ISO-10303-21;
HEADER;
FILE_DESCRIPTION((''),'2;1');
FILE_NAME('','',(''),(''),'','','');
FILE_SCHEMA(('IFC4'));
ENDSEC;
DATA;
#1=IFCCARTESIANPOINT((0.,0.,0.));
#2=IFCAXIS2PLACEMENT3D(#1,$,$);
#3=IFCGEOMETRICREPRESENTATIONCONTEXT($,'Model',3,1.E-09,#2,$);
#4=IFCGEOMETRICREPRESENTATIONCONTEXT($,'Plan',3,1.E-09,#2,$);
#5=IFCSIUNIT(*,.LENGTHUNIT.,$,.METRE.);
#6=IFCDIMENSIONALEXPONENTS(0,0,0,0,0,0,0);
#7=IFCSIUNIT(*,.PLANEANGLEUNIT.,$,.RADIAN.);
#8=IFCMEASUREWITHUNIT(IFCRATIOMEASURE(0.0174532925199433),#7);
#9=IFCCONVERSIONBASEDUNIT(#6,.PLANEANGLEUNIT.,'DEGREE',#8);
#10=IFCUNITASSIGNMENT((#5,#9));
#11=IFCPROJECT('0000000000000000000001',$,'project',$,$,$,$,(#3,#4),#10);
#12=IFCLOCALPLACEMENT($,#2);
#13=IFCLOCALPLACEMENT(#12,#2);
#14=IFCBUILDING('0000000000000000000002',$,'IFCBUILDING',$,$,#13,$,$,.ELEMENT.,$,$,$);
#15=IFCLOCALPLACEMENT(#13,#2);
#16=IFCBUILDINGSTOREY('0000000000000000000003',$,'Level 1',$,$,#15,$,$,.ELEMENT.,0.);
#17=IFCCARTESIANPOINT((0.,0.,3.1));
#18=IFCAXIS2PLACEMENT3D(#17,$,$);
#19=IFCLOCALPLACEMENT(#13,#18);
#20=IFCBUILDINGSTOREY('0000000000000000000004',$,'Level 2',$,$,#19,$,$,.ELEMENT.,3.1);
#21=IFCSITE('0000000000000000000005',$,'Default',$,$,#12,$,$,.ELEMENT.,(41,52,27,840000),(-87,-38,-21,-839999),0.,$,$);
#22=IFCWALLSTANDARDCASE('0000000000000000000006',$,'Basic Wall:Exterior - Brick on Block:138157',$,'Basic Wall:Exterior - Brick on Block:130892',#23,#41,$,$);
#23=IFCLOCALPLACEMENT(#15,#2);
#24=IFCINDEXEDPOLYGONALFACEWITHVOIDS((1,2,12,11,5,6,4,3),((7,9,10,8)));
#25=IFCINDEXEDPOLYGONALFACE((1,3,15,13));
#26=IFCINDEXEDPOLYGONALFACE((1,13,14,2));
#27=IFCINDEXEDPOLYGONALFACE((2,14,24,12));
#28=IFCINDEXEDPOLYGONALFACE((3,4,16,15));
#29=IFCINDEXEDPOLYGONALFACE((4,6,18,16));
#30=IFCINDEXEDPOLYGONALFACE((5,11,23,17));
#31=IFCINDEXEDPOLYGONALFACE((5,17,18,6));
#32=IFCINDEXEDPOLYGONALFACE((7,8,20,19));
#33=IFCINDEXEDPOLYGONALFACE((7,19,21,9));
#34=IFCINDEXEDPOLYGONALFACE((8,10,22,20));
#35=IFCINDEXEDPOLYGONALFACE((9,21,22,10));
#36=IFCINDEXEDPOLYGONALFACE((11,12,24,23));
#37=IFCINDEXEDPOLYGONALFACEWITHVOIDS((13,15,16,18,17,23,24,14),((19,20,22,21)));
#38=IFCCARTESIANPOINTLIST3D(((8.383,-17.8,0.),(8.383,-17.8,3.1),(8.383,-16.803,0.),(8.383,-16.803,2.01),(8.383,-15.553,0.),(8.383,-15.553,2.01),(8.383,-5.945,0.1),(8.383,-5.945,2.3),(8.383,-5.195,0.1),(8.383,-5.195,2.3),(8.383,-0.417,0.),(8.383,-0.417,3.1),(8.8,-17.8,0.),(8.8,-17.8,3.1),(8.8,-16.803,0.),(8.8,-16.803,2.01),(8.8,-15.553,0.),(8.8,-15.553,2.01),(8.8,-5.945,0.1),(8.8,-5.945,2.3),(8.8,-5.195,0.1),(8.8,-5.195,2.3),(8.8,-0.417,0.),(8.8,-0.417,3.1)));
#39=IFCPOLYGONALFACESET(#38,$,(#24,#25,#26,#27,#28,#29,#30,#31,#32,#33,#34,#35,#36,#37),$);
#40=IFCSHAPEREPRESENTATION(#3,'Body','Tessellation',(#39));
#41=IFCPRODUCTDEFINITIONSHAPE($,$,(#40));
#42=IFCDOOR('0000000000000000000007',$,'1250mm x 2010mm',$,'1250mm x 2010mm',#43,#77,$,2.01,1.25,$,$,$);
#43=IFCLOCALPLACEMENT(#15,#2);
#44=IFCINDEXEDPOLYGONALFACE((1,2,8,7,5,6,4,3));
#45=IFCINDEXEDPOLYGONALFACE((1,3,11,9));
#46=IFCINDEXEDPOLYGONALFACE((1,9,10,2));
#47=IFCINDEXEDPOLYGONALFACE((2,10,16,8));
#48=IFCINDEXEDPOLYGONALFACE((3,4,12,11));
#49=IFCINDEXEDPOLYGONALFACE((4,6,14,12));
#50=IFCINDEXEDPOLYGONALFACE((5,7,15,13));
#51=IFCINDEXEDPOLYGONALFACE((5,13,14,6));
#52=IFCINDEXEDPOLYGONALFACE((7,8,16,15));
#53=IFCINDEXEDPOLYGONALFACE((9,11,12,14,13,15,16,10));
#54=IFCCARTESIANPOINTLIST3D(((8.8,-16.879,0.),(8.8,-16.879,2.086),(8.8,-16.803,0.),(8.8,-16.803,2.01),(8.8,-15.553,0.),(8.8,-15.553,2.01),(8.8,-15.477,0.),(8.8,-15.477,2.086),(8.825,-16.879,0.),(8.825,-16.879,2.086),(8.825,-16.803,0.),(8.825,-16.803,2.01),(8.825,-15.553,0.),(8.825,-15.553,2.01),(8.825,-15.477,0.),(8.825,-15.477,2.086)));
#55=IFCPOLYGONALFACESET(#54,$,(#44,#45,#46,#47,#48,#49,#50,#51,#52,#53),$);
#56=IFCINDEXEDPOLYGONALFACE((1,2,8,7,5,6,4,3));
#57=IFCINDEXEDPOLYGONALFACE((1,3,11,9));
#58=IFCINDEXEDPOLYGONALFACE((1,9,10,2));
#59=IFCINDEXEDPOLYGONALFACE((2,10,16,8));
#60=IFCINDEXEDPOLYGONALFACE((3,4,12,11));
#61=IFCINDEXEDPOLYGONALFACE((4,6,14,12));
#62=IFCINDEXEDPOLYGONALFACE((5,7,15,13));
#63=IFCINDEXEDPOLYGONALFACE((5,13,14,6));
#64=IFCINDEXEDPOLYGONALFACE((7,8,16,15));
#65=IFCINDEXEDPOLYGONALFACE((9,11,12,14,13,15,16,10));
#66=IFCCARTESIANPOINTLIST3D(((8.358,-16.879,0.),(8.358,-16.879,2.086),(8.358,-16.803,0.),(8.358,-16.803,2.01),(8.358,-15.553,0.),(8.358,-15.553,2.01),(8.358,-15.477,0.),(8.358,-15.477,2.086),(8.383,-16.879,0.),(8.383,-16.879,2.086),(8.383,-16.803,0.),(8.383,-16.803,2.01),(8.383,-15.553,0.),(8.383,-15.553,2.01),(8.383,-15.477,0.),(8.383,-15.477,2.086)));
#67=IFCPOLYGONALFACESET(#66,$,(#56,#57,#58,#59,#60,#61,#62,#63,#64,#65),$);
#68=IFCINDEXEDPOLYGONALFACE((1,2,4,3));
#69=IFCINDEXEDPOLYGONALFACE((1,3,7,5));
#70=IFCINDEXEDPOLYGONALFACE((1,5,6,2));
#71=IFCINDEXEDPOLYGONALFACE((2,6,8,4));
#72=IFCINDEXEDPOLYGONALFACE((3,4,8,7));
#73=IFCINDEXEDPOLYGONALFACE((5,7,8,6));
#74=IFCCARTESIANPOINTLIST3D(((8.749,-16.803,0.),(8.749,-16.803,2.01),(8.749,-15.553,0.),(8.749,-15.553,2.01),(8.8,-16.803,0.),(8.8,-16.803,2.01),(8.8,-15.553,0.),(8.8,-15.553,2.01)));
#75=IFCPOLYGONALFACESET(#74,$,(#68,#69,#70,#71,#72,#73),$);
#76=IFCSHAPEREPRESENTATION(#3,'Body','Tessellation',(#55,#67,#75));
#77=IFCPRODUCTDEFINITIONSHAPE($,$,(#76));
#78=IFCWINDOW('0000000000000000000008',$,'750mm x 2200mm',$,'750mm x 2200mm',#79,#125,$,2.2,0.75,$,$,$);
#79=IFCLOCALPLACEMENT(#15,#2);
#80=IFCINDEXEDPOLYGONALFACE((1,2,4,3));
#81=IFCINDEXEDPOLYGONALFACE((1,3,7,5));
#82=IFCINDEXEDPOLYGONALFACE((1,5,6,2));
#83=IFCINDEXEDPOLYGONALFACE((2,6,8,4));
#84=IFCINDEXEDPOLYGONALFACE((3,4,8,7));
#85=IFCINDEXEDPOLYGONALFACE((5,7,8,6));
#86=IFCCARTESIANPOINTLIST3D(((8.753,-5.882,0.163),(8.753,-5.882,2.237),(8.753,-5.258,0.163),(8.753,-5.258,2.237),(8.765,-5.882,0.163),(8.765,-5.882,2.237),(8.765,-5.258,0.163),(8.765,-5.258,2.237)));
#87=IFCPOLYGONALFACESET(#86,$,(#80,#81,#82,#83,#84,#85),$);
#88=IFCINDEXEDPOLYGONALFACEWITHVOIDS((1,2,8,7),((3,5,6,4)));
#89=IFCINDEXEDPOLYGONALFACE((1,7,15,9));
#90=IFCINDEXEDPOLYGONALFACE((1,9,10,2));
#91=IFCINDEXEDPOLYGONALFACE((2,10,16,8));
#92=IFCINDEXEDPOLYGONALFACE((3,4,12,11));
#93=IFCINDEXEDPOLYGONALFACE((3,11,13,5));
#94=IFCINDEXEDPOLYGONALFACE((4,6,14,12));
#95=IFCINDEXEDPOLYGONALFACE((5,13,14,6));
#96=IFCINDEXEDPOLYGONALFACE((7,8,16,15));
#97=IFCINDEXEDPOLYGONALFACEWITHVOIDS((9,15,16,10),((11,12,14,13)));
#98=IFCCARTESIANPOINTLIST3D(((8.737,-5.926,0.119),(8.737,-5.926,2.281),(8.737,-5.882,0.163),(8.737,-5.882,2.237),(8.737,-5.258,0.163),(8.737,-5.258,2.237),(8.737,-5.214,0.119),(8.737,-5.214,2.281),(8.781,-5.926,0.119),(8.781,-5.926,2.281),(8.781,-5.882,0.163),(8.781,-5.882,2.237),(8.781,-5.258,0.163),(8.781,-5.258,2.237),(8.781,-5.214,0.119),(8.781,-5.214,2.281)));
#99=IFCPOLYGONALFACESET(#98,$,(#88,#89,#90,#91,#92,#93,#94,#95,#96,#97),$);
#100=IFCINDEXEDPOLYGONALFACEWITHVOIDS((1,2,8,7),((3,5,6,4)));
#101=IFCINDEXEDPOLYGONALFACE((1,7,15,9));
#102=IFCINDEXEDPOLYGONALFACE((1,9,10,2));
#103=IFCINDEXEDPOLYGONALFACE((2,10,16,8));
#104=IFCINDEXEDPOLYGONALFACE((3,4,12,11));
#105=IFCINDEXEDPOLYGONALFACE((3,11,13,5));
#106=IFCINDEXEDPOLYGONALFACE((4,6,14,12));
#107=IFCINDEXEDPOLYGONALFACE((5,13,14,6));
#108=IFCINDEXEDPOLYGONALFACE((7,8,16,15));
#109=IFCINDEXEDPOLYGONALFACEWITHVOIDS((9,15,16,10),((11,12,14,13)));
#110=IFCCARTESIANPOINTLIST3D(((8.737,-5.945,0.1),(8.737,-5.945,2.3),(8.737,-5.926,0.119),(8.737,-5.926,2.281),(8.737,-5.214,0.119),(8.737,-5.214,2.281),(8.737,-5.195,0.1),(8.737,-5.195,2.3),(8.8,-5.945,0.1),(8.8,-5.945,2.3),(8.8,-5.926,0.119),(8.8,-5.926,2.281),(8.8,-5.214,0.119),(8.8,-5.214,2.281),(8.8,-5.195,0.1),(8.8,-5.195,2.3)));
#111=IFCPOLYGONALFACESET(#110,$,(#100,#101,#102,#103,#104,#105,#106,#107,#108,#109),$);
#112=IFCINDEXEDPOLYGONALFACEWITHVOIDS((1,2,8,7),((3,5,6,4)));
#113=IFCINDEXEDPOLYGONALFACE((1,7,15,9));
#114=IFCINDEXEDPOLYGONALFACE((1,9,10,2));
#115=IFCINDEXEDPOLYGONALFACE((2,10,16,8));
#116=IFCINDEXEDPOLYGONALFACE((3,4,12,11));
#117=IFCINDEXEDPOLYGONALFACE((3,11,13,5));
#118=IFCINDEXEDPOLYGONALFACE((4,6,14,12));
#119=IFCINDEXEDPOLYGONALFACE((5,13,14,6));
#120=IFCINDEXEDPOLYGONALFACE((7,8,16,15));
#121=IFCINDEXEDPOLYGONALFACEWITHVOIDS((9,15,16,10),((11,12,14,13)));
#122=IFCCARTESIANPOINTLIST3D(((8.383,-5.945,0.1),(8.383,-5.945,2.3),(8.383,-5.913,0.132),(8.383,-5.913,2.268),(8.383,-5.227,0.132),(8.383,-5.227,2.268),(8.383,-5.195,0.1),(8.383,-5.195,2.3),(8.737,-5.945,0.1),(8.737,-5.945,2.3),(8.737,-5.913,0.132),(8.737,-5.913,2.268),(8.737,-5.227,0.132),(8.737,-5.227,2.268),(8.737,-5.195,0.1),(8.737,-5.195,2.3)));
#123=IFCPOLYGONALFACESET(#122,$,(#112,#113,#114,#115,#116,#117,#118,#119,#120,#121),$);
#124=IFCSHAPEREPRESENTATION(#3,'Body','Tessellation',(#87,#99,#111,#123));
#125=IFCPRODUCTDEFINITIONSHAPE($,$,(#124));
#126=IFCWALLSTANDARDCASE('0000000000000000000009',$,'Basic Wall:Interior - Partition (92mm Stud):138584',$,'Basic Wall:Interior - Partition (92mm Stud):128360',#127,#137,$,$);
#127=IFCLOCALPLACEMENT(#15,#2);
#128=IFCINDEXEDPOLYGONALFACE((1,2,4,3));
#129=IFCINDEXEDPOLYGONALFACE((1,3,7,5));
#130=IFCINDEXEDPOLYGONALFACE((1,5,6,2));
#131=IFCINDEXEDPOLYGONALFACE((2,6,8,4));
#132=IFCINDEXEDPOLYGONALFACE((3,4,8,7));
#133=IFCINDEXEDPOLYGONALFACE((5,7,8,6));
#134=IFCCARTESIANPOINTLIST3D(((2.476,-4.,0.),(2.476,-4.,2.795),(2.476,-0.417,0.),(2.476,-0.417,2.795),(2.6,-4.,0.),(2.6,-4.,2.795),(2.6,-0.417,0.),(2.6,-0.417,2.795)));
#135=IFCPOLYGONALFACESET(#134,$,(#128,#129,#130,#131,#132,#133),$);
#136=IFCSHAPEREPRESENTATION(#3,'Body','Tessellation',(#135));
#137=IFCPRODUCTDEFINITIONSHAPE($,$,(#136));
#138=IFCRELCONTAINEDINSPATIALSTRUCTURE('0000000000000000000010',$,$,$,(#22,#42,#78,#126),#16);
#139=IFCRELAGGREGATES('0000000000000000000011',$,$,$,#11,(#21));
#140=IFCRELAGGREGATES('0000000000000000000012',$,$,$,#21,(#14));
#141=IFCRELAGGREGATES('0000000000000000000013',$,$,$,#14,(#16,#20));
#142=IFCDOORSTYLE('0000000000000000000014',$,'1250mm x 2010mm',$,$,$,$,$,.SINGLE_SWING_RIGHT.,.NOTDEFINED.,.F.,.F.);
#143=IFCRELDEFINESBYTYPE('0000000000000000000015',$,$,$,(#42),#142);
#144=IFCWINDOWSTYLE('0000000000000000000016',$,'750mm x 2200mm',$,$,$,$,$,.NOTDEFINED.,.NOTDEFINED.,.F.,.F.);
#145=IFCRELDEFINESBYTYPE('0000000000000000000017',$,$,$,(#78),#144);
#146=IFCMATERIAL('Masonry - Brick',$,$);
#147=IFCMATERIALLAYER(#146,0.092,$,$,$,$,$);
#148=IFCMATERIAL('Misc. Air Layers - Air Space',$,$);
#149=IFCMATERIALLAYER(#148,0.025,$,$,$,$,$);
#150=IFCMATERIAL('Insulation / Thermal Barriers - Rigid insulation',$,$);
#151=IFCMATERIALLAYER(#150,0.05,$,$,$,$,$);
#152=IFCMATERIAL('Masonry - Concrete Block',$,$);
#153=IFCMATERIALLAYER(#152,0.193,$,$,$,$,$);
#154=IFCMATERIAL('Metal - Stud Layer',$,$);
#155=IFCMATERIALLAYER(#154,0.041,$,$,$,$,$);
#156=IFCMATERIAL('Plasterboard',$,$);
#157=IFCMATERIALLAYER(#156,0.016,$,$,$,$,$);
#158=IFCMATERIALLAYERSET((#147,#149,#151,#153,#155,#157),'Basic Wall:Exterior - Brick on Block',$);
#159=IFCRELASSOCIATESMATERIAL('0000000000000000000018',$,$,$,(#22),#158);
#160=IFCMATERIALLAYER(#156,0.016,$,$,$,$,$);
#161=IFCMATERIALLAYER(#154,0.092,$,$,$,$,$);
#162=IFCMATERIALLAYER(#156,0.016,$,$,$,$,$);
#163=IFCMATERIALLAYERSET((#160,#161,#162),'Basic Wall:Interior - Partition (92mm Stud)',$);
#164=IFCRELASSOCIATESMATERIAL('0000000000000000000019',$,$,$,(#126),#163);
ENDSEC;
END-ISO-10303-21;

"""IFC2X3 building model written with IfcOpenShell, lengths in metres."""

from ifc_helpers import new_model, entity, si_unit, converted_unit, frame, frame_2d, origin, origin_2d_with_axis, place, context, project, spatial, polyline, rectangle, outline, extrude, source, transform, mapped, material, layer, layer_set, layer_usage, type_object, type_shapes, element, fill, save


model = new_model("IFC2X3")

# Units and contexts
model_context = context("Model", 3, precision=1e-09, world=origin())
plan_context = context("Plan", 3, precision=1e-09, world=origin())
ifc_project = project(units=[si_unit("LENGTHUNIT", "METRE"), converted_unit("PLANEANGLEUNIT", "DEGREE", entity("IfcRatioMeasure", 0.0174532925199433), si_unit("PLANEANGLEUNIT", "RADIAN"), dimensions=[0, 0, 0, 0, 0, 0, 0])], contexts=[model_context, plan_context])

# Site, building, storey
site_placement = place(None, origin())
site = spatial("IfcSite", under=ifc_project, at=site_placement, Name="Default", CompositionType="ELEMENT", RefLatitude=(41, 52, 27, 840000), RefLongitude=(-87, -38, -21, -839999), RefElevation=0.0)
building_placement = place(site_placement, origin())
building = spatial("IfcBuilding", under=site, at=building_placement, Name="IFCBUILDING", CompositionType="ELEMENT")
storey_1_placement = place(building_placement, origin())
storey_1 = spatial("IfcBuildingStorey", under=building, at=storey_1_placement, Name="Level 1", CompositionType="ELEMENT", Elevation=0.0)

# Shared definitions
ifc_material_1 = material(Name="Masonry - Brick")
ifc_layer_1 = layer(ifc_material_1, 0.092)
ifc_material_2 = material(Name="Misc. Air Layers - Air Space")
ifc_layer_2 = layer(ifc_material_2, 0.025)
ifc_material_3 = material(Name="Insulation / Thermal Barriers - Rigid insulation")
ifc_layer_3 = layer(ifc_material_3, 0.05)
ifc_material_4 = material(Name="Masonry - Concrete Block")
ifc_layer_4 = layer(ifc_material_4, 0.193)
ifc_material_5 = material(Name="Metal - Stud Layer")
ifc_layer_5 = layer(ifc_material_5, 0.041)
ifc_material_6 = material(Name="Plasterboard")
ifc_layer_6 = layer(ifc_material_6, 0.016)
ifc_layer_set_1 = layer_set([ifc_layer_1, ifc_layer_2, ifc_layer_3, ifc_layer_4, ifc_layer_5, ifc_layer_6], Name="Basic Wall:Exterior - Brick on Block")

# Wall, openings, door, window
ifc_layer_usage_1 = layer_usage(ifc_layer_set_1, "AXIS2", "NEGATIVE", 0.2085)
wall_1_placement = place(storey_1_placement, frame((8.5915, -0.417, 0.0), z_axis=(0.0, 0.0, 1.0), x_axis=(0.0, -1.0, 0.0)))
wall_1 = element("IfcWallStandardCase", 1, at=wall_1_placement, inside=storey_1, material=ifc_layer_usage_1, Name="Basic Wall:Exterior - Brick on Block:138157", ObjectType="Basic Wall:Exterior - Brick on Block:130892", context=model_context, shape_type="SweptSolid", body=[
    extrude(rectangle(XDim=17.383, YDim=0.417, at=frame_2d((8.6915, 0.0), x_axis=(-1.0, 0.0))), origin(), (0.0, 0.0, 1.0), 3.1),
])
opening_1_placement = place(wall_1_placement, frame((15.136, -0.2085, 0.0)))
opening_1 = element("IfcOpeningElement", 2, at=opening_1_placement, cuts=wall_1, ObjectType="Opening", context=model_context, shape_type="SweptSolid", body=[
    extrude(rectangle(XDim=1.25, YDim=2.01, at=frame_2d((1.005, 0.625), x_axis=(0.0, 1.0))), frame((0.0, 0.0, 0.0), z_axis=(0.0, 1.0, 0.0), x_axis=(0.0, 0.0, 1.0)), (0.0, 0.0, 1.0), 0.417),
])
opening_2_placement = place(wall_1_placement, frame((4.778, -0.2085, 0.1)))
opening_2 = element("IfcOpeningElement", 3, at=opening_2_placement, cuts=wall_1, ObjectType="Opening", context=model_context, shape_type="SweptSolid", body=[
    extrude(rectangle(XDim=2.2, YDim=0.75, at=frame_2d((1.1, 0.375), x_axis=(1.0, 0.0))), frame((0.0, 0.0, 0.0), z_axis=(0.0, 1.0, 0.0), x_axis=(0.0, 0.0, 1.0)), (0.0, 0.0, 1.0), 0.417),
])
door_style_1 = type_object("IfcDoorStyle", Name="1250mm x 2010mm", ConstructionType="NOTDEFINED", OperationType="SINGLE_SWING_RIGHT", ParameterTakesPrecedence=False, Sizeable=False)
shared_shape_1 = source(origin(), model_context, "Body", "SweptSolid", [
    extrude(outline(polyline([(-0.701, -1.062), (0.701, -1.062), (0.701, 1.024), (0.625, 1.024), (0.625, -0.986), (-0.625, -0.986), (-0.625, 1.024), (-0.701, 1.024), (-0.701, -1.062)])), frame((0.625, 0.417, 1.024), z_axis=(0.0, 1.0, 0.0), x_axis=(1.0, 0.0, 0.0)), (0.0, 0.0, 1.0), 0.025),
    extrude(outline(polyline([(-1.062, -0.701), (1.024, -0.701), (1.024, -0.625), (-0.986, -0.625), (-0.986, 0.625), (1.024, 0.625), (1.024, 0.701), (-1.062, 0.701), (-1.062, -0.701)])), frame((0.625, -0.025, 1.024), z_axis=(0.0, 1.0, 0.0), x_axis=(0.0, 0.0, -1.0)), (0.0, 0.0, 1.0), 0.025),
    extrude(rectangle(XDim=0.051, YDim=1.25, at=origin_2d_with_axis()), frame((0.625, 0.3915, 0.0), z_axis=(0.0, 0.0, 1.0), x_axis=(0.0, 1.0, 0.0)), (0.0, 0.0, 1.0), 2.01),
])
type_shapes(door_style_1, [shared_shape_1])
door_1_placement = place(opening_1_placement, origin())
door_1 = element("IfcDoor", 4, at=door_1_placement, inside=storey_1, type_object=door_style_1, Name="1250mm x 2010mm", ObjectType="1250mm x 2010mm", OverallHeight=2.01, OverallWidth=1.25, context=model_context, shape_type="MappedRepresentation", body=[
    mapped(shared_shape_1, transform((0.0, 0.0, 0.0), scale=1.0)),
])
fill(opening_1, door_1)
window_style_1 = type_object("IfcWindowStyle", Name="750mm x 2200mm", ConstructionType="NOTDEFINED", OperationType="NOTDEFINED", ParameterTakesPrecedence=False, Sizeable=False)
shared_shape_2 = source(origin(), model_context, "Body", "SweptSolid", [
    extrude(rectangle(XDim=0.012, YDim=0.624, at=origin_2d_with_axis()), frame((0.375, 0.376, 0.063), z_axis=(0.0, 0.0, 1.0), x_axis=(0.0, -1.0, 0.0)), (0.0, 0.0, 1.0), 2.074),
    extrude(outline(polyline([(-0.356, -1.081), (0.356, -1.081), (0.356, 1.081), (-0.356, 1.081), (-0.356, -1.081)]), holes=[polyline([(-0.312, -1.037), (-0.312, 1.037), (0.312, 1.037), (0.312, -1.037), (-0.312, -1.037)])]), frame((0.375, 0.354, 1.1), z_axis=(0.0, 1.0, 0.0), x_axis=(1.0, 0.0, 0.0)), (0.0, 0.0, 1.0), 0.044),
    extrude(outline(polyline([(-0.375, -1.1), (0.375, -1.1), (0.375, 1.1), (-0.375, 1.1), (-0.375, -1.1)]), holes=[polyline([(-0.356, -1.081), (-0.356, 1.081), (0.356, 1.081), (0.356, -1.081), (-0.356, -1.081)])]), frame((0.375, 0.354, 1.1), z_axis=(0.0, 1.0, 0.0), x_axis=(1.0, 0.0, 0.0)), (0.0, 0.0, 1.0), 0.063),
    extrude(outline(polyline([(-0.375, -1.1), (0.375, -1.1), (0.375, 1.1), (-0.375, 1.1), (-0.375, -1.1)]), holes=[polyline([(-0.343, -1.068), (-0.343, 1.068), (0.343, 1.068), (0.343, -1.068), (-0.343, -1.068)])]), frame((0.375, 0.0, 1.1), z_axis=(0.0, 1.0, 0.0), x_axis=(1.0, 0.0, 0.0)), (0.0, 0.0, 1.0), 0.354),
])
type_shapes(window_style_1, [shared_shape_2])
window_1_placement = place(opening_2_placement, origin())
window_1 = element("IfcWindow", 5, at=window_1_placement, inside=storey_1, type_object=window_style_1, Name="750mm x 2200mm", ObjectType="750mm x 2200mm", OverallHeight=2.2, OverallWidth=0.75, context=model_context, shape_type="MappedRepresentation", body=[
    mapped(shared_shape_2, transform((0.0, 0.0, 0.0), scale=1.0)),
])
fill(opening_2, window_1)

# Wall
ifc_layer_7 = layer(ifc_material_6, 0.016)
ifc_layer_8 = layer(ifc_material_5, 0.092)
ifc_layer_9 = layer(ifc_material_6, 0.016)
ifc_layer_set_2 = layer_set([ifc_layer_7, ifc_layer_8, ifc_layer_9], Name="Basic Wall:Interior - Partition (92mm Stud)")
ifc_layer_usage_2 = layer_usage(ifc_layer_set_2, "AXIS2", "NEGATIVE", 0.062)
wall_2_placement = place(storey_1_placement, frame((2.538, -0.417, 0.0), z_axis=(0.0, 0.0, 1.0), x_axis=(0.0, -1.0, 0.0)))
element("IfcWallStandardCase", 6, at=wall_2_placement, inside=storey_1, material=ifc_layer_usage_2, Name="Basic Wall:Interior - Partition (92mm Stud):138584", ObjectType="Basic Wall:Interior - Partition (92mm Stud):128360", context=model_context, shape_type="SweptSolid", body=[
    extrude(rectangle(XDim=3.583, YDim=0.124, at=frame_2d((1.7915, 0.0), x_axis=(-1.0, 0.0))), origin(), (0.0, 0.0, 1.0), 2.795),
])

# Shared definitions
storey_2_placement = place(building_placement, frame((0.0, 0.0, 3.1)))
storey_2 = spatial("IfcBuildingStorey", under=building, at=storey_2_placement, Name="Level 2", CompositionType="ELEMENT", Elevation=3.1)

save(model, "model.ifc")
